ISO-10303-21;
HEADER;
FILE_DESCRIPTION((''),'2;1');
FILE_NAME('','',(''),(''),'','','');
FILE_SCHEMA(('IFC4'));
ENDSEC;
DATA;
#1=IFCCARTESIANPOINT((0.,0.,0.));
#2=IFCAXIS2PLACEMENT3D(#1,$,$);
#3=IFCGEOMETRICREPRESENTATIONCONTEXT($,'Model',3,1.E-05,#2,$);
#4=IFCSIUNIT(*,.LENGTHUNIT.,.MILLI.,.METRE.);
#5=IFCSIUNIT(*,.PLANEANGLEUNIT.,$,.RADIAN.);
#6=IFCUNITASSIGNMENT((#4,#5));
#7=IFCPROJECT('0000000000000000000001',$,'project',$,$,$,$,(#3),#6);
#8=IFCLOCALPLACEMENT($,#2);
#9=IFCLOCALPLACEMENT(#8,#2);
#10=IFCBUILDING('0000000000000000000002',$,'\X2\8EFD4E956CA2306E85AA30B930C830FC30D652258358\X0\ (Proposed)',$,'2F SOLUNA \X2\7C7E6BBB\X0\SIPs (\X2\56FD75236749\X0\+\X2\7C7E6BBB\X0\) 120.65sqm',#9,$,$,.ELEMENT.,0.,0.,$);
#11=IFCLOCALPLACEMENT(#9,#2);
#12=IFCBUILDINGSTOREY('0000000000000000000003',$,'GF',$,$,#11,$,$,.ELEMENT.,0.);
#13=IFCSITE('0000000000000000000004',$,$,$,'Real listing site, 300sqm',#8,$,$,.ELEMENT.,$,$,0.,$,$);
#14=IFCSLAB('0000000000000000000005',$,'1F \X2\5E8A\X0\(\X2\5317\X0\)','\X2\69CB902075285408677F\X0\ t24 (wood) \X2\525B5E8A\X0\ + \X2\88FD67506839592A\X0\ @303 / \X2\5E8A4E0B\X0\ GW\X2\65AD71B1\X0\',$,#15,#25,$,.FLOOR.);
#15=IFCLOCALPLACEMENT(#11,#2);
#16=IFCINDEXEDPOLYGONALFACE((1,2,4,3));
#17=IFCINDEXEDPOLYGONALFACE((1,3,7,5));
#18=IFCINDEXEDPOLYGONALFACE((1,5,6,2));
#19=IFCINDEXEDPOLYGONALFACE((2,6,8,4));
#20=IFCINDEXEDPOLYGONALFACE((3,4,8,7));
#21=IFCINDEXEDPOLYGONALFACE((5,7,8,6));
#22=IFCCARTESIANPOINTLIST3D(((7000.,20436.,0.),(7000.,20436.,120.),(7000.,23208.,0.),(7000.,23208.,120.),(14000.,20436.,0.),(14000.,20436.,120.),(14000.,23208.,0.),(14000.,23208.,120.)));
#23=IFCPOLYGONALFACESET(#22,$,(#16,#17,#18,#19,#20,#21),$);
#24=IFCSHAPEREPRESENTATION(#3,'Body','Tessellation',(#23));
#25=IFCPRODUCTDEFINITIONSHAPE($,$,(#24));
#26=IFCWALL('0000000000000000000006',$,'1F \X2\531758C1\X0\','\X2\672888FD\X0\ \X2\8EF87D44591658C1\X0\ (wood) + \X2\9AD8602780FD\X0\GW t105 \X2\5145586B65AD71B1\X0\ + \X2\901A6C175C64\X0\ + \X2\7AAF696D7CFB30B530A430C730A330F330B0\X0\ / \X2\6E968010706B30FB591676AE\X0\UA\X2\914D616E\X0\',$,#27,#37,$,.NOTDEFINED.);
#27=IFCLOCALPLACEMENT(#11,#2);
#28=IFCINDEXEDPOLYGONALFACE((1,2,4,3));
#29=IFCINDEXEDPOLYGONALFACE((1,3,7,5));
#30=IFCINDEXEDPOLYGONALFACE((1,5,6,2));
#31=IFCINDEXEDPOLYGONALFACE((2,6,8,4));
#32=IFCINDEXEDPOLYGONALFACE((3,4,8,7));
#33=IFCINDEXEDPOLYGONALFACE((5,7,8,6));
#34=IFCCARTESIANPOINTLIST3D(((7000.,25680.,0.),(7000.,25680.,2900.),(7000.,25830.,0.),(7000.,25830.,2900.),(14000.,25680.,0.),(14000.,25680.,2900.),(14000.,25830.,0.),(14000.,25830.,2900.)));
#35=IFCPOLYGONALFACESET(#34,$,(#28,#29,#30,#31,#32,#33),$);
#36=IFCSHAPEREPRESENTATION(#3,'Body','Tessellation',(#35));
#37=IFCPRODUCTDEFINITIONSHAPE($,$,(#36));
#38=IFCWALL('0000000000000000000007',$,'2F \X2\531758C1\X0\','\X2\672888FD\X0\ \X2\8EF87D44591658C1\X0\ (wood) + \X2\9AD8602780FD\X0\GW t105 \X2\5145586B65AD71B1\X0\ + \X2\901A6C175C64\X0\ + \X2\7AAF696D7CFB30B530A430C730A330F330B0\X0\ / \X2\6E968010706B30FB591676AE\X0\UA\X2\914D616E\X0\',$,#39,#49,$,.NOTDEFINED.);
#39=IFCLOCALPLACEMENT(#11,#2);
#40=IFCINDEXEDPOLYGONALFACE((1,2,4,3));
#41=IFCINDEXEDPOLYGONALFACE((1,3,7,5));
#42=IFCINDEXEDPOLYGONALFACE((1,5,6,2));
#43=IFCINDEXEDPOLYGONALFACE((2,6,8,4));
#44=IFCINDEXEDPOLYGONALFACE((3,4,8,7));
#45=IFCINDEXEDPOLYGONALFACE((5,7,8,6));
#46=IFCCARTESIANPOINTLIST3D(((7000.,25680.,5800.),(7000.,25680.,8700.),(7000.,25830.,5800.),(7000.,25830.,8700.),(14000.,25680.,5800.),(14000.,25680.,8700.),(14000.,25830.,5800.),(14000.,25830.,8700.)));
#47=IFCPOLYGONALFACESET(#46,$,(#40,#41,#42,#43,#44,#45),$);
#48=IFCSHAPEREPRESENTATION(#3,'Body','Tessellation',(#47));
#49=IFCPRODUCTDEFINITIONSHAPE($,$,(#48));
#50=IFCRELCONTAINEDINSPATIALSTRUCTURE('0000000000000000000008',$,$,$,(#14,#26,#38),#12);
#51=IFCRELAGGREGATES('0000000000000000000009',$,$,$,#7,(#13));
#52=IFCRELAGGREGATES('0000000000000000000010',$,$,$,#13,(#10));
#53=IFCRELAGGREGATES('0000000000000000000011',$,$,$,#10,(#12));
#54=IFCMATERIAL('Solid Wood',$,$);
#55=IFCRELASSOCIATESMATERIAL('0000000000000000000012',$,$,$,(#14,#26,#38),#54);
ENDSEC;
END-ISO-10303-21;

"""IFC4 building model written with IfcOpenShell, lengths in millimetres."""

from ifc_helpers import new_model, si_unit, frame, frame_2d, origin, place, context, project, spatial, rectangle, extrude, material, element, save


model = new_model("IFC4")

# Units and contexts
model_context = context("Model", 3, precision=1e-05, world=origin())
ifc_project = project(units=[si_unit("LENGTHUNIT", "METRE", prefix="MILLI"), si_unit("PLANEANGLEUNIT", "RADIAN")], contexts=[model_context])

# Site, building, storey
site_placement = place(None, origin())
site = spatial("IfcSite", under=ifc_project, at=site_placement, ObjectType="Real listing site, 300sqm", CompositionType="ELEMENT", RefElevation=0.0)
building_placement = place(site_placement, origin())
building = spatial("IfcBuilding", under=site, at=building_placement, Name="軽井沢の薪ストーブ別荘 (Proposed)", ObjectType="2F SOLUNA 籾殻SIPs (国産杉+籾殻) 120.65sqm", CompositionType="ELEMENT", ElevationOfRefHeight=0.0, ElevationOfTerrain=0.0)
storey_placement = place(building_placement, origin())
storey = spatial("IfcBuildingStorey", under=building, at=storey_placement, Name="GF", CompositionType="ELEMENT", Elevation=0.0)

# Slab
ifc_material_1 = material(Name="Solid Wood")
slab_1_placement = place(storey_placement, frame((3500.0, 10218.0, 0.0)))
element("IfcSlab", 1, at=slab_1_placement, inside=storey, material=ifc_material_1, Name="1F 床(北)", Description="構造用合板 t24 (wood) 剛床 + 製材根太 @303 / 床下 GW断熱", PredefinedType="FLOOR", context=model_context, shape_type="SweptSolid", body=[
    extrude(rectangle(XDim=7000.0, YDim=2772.0, at=frame_2d((3500.0, 1386.0))), frame((3500.0, 10218.0, 0.0)), (0.0, 0.0, 1.0), 120.0),
])

# Wall
wall_1_placement = place(storey_placement, frame((3500.0, 12840.0, 0.0)))
element("IfcWall", 2, at=wall_1_placement, inside=storey, material=ifc_material_1, Name="1F 北壁", Description="木製 軸組外壁 (wood) + 高性能GW t105 充填断熱 + 通気層 + 窯業系サイディング / 準耐火・外皮UA配慮", PredefinedType="NOTDEFINED", context=model_context, shape_type="SweptSolid", body=[
    extrude(rectangle(XDim=7000.0, YDim=150.0, at=frame_2d((3500.0, 75.0))), frame((3500.0, 12840.0, 0.0)), (0.0, 0.0, 1.0), 2900.0),
])

# Wall
wall_2_placement = place(storey_placement, frame((3500.0, 12840.0, 2900.0)))
element("IfcWall", 3, at=wall_2_placement, inside=storey, material=ifc_material_1, Name="2F 北壁", Description="木製 軸組外壁 (wood) + 高性能GW t105 充填断熱 + 通気層 + 窯業系サイディング / 準耐火・外皮UA配慮", PredefinedType="NOTDEFINED", context=model_context, shape_type="SweptSolid", body=[
    extrude(rectangle(XDim=7000.0, YDim=150.0, at=frame_2d((3500.0, 75.0))), frame((3500.0, 12840.0, 2900.0)), (0.0, 0.0, 1.0), 2900.0),
])

save(model, "model.ifc")
